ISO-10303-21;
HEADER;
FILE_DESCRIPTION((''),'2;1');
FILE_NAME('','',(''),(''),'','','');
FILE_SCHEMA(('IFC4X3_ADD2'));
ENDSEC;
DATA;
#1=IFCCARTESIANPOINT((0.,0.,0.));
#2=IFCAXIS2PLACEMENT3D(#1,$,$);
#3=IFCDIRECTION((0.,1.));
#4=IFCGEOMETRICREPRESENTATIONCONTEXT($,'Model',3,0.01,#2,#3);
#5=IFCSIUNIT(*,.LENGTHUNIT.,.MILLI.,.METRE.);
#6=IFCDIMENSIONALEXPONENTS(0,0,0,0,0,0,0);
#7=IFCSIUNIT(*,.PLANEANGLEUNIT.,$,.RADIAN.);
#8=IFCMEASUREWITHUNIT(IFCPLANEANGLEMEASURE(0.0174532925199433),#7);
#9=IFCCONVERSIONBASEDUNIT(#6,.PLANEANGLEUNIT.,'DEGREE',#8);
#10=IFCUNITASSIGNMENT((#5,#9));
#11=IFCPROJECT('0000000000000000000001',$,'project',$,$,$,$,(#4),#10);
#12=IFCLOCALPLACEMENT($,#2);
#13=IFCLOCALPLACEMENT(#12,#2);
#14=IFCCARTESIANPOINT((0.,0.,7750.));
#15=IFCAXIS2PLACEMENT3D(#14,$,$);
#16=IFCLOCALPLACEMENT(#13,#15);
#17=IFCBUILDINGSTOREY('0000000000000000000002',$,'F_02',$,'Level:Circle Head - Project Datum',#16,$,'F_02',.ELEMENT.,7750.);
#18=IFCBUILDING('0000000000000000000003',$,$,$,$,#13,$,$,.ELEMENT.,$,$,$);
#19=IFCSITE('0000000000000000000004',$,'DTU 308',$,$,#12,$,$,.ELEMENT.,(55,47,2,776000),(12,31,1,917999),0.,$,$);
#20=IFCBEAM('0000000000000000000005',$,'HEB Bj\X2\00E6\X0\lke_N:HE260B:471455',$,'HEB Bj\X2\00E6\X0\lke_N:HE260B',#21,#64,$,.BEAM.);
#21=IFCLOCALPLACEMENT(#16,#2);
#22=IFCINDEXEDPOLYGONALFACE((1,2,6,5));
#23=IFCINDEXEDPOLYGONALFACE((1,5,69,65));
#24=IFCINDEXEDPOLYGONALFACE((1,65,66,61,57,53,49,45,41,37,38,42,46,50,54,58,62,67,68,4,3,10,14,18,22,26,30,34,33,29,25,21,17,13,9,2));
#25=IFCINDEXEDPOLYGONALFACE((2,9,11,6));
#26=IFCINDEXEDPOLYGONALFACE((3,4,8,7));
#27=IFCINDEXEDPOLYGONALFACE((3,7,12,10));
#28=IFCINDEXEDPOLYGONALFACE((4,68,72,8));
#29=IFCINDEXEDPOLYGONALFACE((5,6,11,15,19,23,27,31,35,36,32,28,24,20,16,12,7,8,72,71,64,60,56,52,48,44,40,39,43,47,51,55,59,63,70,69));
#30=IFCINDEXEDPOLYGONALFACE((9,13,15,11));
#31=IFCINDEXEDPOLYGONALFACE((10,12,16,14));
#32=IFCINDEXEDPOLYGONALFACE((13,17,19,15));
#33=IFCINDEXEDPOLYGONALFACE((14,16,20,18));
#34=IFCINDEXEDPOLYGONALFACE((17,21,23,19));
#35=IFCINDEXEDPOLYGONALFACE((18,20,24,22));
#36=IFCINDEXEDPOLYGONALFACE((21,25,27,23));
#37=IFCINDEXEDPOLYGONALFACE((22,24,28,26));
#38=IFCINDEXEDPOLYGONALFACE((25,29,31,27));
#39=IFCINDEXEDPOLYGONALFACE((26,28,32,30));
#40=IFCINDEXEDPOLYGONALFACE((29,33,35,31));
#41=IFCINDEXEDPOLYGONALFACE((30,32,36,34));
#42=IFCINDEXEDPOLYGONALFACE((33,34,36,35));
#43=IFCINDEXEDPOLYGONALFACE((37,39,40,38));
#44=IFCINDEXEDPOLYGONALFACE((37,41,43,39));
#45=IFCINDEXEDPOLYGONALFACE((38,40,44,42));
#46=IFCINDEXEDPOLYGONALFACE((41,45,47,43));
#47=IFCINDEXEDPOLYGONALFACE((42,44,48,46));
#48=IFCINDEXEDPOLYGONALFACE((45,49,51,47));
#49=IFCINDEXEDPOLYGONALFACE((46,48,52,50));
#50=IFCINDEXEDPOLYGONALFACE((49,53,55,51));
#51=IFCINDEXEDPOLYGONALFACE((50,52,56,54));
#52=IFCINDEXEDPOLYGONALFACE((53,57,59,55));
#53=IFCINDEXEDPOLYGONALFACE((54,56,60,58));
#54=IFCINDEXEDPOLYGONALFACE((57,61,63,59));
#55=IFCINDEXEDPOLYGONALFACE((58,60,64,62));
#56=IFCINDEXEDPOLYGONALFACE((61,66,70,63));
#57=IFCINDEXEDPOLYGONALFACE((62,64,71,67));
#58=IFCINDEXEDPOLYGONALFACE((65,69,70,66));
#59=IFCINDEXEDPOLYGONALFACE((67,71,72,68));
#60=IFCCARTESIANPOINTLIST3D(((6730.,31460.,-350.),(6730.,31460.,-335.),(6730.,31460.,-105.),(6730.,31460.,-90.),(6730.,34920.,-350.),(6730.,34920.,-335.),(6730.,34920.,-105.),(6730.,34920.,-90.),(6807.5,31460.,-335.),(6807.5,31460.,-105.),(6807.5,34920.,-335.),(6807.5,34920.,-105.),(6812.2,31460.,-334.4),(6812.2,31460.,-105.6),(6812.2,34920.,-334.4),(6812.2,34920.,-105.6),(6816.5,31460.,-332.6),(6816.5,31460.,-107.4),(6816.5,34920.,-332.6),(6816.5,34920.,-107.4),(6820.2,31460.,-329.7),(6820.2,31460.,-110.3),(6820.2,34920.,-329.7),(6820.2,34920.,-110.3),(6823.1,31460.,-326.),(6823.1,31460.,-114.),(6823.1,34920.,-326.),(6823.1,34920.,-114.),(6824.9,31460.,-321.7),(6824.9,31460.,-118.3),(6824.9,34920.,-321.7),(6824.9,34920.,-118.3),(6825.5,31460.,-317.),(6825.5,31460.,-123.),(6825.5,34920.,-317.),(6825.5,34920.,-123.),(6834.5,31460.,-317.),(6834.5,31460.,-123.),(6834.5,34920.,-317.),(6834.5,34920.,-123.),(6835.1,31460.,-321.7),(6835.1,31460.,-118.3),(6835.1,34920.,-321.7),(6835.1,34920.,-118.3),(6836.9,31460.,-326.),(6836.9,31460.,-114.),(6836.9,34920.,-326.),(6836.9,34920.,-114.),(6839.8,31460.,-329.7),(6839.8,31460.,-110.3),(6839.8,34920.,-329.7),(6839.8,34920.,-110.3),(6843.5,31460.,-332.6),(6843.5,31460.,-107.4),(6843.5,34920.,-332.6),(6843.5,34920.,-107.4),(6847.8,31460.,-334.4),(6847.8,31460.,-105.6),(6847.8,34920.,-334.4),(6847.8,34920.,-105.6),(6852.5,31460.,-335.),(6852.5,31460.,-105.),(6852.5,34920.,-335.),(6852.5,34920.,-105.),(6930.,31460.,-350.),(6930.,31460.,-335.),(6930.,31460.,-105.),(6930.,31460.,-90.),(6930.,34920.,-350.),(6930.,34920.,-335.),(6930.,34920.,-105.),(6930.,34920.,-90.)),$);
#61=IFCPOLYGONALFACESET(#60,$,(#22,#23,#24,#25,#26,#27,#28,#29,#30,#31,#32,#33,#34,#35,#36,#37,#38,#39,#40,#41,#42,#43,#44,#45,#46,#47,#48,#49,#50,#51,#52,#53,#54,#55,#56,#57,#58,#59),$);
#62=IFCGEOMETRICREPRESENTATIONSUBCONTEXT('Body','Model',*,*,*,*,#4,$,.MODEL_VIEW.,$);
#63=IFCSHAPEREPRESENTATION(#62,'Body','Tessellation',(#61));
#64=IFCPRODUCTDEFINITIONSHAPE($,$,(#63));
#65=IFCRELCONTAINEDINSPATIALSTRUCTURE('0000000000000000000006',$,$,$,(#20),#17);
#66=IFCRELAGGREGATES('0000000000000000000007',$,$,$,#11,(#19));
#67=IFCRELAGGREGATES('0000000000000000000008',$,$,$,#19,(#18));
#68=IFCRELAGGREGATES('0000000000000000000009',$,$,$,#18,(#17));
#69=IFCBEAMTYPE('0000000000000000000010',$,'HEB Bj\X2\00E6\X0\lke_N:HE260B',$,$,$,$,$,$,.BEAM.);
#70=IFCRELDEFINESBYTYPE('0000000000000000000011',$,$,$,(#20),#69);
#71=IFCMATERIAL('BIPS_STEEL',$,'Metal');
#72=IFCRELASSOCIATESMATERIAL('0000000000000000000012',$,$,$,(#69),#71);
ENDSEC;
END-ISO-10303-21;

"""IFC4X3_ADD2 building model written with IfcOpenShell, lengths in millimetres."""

from ifc_helpers import new_model, entity, si_unit, converted_unit, direction, frame, frame_2d, origin, place, context, subcontext, project, spatial, polyline, circle_curve, parameter, trimmed, segment, composite_curve, i_section, outline, extrude, source, transform, mapped, material, material_profile, profile_set, type_object, element, save


model = new_model("IFC4X3_ADD2")

# Units and contexts
model_context = context("Model", 3, precision=0.01, world=origin(), true_north=direction((0.0, 1.0)))
body_context = subcontext(model_context, "Body", "Model", "MODEL_VIEW")
ifc_project = project(units=[si_unit("LENGTHUNIT", "METRE", prefix="MILLI"), converted_unit("PLANEANGLEUNIT", "DEGREE", entity("IfcPlaneAngleMeasure", 0.0174532925199433), si_unit("PLANEANGLEUNIT", "RADIAN"), dimensions=[0, 0, 0, 0, 0, 0, 0])], contexts=[model_context])

# Site, building, storey
site_placement = place(None, origin())
site = spatial("IfcSite", under=ifc_project, at=site_placement, Name="DTU 308", CompositionType="ELEMENT", RefLatitude=(55, 47, 2, 776000), RefLongitude=(12, 31, 1, 917999), RefElevation=0.0)
building_placement = place(site_placement, origin())
building = spatial("IfcBuilding", under=site, at=building_placement, CompositionType="ELEMENT")
storey_placement = place(building_placement, frame((0.0, 0.0, 7750.0)))
storey = spatial("IfcBuildingStorey", under=building, at=storey_placement, Name="F_02", ObjectType="Level:Circle Head - Project Datum", LongName="F_02", CompositionType="ELEMENT", Elevation=7750.0)

# Shared definitions
ifc_material = material(Name="BIPS_STEEL", Category="Metal")

# Beam
ifc_material_profile_1 = material_profile(ifc_material, i_section(OverallWidth=200.0, OverallDepth=260.0, WebThickness=9.0, FlangeThickness=15.0, FilletRadius=18.0, at=frame_2d((0.0, 0.0), x_axis=(1.0, 0.0))), Name="HE260B")
ifc_profile_set_1 = profile_set([ifc_material_profile_1], Name="HE260B")
beam_type_1 = type_object("IfcBeamType", Name="HEB Bjælke_N:HE260B", PredefinedType="BEAM", material=ifc_profile_set_1)
shared_shape_1 = source(origin(), body_context, "Body", "SweptSolid", [
    extrude(outline(composite_curve([segment(polyline([(-100.0, -115.0), (-100.0, -130.0)]), True, "CONTINUOUS"), segment(polyline([(-100.0, -130.0), (100.0, -130.0)]), True, "CONTINUOUS"), segment(polyline([(100.0, -130.0), (100.0, -115.0)]), True, "CONTINUOUS"), segment(polyline([(100.0, -115.0), (22.5, -115.0)]), True, "CONTINUOUS"), segment(trimmed(circle_curve(frame_2d((22.5, -97.0), x_axis=(1.0, 0.0)), 18.0), [parameter(180.0)], [parameter(270.0)], True, "PARAMETER"), False, "CONTINUOUS"), segment(polyline([(4.5, -97.0), (4.5, 97.0)]), True, "CONTINUOUS"), segment(trimmed(circle_curve(frame_2d((22.5, 97.0), x_axis=(1.0, 0.0)), 18.0), [parameter(90.0)], [parameter(180.0)], True, "PARAMETER"), False, "CONTINUOUS"), segment(polyline([(22.5, 115.0), (100.0, 115.0)]), True, "CONTINUOUS"), segment(polyline([(100.0, 115.0), (100.0, 130.0)]), True, "CONTINUOUS"), segment(polyline([(100.0, 130.0), (-100.0, 130.0)]), True, "CONTINUOUS"), segment(polyline([(-100.0, 130.0), (-100.0, 115.0)]), True, "CONTINUOUS"), segment(polyline([(-100.0, 115.0), (-22.5, 115.0)]), True, "CONTINUOUS"), segment(trimmed(circle_curve(frame_2d((-22.5, 97.0), x_axis=(1.0, 0.0)), 18.0), [parameter(360.0)], [parameter(90.0)], True, "PARAMETER"), False, "CONTINUOUS"), segment(polyline([(-4.5, 97.0), (-4.5, -97.0)]), True, "CONTINUOUS"), segment(trimmed(circle_curve(frame_2d((-22.5, -97.0), x_axis=(1.0, 0.0)), 18.0), [parameter(270.0)], [parameter(360.0)], True, "PARAMETER"), False, "CONTINUOUS"), segment(polyline([(-22.5, -115.0), (-100.0, -115.0)]), True, "CONTINUOUS")], self_intersect=False)), frame((-1670.0, 0.0, 0.0), z_axis=(-1.0, 0.0, 0.0), x_axis=(0.0, -1.0, 0.0)), (0.0, 0.0, -1.0), 3460.0),
])
beam_1_placement = place(storey_placement, frame((6830.0, 33250.0, -220.0), z_axis=(0.0, 0.0, 1.0), x_axis=(0.0, -1.0, 0.0)))
element("IfcBeam", 1, at=beam_1_placement, inside=storey, type_object=beam_type_1, Name="HEB Bjælke_N:HE260B:471455", ObjectType="HEB Bjælke_N:HE260B", PredefinedType="BEAM", context=body_context, shape_type="MappedRepresentation", body=[
    mapped(shared_shape_1, transform((0.0, 0.0, 0.0), scale=1.0)),
])

save(model, "model.ifc")
